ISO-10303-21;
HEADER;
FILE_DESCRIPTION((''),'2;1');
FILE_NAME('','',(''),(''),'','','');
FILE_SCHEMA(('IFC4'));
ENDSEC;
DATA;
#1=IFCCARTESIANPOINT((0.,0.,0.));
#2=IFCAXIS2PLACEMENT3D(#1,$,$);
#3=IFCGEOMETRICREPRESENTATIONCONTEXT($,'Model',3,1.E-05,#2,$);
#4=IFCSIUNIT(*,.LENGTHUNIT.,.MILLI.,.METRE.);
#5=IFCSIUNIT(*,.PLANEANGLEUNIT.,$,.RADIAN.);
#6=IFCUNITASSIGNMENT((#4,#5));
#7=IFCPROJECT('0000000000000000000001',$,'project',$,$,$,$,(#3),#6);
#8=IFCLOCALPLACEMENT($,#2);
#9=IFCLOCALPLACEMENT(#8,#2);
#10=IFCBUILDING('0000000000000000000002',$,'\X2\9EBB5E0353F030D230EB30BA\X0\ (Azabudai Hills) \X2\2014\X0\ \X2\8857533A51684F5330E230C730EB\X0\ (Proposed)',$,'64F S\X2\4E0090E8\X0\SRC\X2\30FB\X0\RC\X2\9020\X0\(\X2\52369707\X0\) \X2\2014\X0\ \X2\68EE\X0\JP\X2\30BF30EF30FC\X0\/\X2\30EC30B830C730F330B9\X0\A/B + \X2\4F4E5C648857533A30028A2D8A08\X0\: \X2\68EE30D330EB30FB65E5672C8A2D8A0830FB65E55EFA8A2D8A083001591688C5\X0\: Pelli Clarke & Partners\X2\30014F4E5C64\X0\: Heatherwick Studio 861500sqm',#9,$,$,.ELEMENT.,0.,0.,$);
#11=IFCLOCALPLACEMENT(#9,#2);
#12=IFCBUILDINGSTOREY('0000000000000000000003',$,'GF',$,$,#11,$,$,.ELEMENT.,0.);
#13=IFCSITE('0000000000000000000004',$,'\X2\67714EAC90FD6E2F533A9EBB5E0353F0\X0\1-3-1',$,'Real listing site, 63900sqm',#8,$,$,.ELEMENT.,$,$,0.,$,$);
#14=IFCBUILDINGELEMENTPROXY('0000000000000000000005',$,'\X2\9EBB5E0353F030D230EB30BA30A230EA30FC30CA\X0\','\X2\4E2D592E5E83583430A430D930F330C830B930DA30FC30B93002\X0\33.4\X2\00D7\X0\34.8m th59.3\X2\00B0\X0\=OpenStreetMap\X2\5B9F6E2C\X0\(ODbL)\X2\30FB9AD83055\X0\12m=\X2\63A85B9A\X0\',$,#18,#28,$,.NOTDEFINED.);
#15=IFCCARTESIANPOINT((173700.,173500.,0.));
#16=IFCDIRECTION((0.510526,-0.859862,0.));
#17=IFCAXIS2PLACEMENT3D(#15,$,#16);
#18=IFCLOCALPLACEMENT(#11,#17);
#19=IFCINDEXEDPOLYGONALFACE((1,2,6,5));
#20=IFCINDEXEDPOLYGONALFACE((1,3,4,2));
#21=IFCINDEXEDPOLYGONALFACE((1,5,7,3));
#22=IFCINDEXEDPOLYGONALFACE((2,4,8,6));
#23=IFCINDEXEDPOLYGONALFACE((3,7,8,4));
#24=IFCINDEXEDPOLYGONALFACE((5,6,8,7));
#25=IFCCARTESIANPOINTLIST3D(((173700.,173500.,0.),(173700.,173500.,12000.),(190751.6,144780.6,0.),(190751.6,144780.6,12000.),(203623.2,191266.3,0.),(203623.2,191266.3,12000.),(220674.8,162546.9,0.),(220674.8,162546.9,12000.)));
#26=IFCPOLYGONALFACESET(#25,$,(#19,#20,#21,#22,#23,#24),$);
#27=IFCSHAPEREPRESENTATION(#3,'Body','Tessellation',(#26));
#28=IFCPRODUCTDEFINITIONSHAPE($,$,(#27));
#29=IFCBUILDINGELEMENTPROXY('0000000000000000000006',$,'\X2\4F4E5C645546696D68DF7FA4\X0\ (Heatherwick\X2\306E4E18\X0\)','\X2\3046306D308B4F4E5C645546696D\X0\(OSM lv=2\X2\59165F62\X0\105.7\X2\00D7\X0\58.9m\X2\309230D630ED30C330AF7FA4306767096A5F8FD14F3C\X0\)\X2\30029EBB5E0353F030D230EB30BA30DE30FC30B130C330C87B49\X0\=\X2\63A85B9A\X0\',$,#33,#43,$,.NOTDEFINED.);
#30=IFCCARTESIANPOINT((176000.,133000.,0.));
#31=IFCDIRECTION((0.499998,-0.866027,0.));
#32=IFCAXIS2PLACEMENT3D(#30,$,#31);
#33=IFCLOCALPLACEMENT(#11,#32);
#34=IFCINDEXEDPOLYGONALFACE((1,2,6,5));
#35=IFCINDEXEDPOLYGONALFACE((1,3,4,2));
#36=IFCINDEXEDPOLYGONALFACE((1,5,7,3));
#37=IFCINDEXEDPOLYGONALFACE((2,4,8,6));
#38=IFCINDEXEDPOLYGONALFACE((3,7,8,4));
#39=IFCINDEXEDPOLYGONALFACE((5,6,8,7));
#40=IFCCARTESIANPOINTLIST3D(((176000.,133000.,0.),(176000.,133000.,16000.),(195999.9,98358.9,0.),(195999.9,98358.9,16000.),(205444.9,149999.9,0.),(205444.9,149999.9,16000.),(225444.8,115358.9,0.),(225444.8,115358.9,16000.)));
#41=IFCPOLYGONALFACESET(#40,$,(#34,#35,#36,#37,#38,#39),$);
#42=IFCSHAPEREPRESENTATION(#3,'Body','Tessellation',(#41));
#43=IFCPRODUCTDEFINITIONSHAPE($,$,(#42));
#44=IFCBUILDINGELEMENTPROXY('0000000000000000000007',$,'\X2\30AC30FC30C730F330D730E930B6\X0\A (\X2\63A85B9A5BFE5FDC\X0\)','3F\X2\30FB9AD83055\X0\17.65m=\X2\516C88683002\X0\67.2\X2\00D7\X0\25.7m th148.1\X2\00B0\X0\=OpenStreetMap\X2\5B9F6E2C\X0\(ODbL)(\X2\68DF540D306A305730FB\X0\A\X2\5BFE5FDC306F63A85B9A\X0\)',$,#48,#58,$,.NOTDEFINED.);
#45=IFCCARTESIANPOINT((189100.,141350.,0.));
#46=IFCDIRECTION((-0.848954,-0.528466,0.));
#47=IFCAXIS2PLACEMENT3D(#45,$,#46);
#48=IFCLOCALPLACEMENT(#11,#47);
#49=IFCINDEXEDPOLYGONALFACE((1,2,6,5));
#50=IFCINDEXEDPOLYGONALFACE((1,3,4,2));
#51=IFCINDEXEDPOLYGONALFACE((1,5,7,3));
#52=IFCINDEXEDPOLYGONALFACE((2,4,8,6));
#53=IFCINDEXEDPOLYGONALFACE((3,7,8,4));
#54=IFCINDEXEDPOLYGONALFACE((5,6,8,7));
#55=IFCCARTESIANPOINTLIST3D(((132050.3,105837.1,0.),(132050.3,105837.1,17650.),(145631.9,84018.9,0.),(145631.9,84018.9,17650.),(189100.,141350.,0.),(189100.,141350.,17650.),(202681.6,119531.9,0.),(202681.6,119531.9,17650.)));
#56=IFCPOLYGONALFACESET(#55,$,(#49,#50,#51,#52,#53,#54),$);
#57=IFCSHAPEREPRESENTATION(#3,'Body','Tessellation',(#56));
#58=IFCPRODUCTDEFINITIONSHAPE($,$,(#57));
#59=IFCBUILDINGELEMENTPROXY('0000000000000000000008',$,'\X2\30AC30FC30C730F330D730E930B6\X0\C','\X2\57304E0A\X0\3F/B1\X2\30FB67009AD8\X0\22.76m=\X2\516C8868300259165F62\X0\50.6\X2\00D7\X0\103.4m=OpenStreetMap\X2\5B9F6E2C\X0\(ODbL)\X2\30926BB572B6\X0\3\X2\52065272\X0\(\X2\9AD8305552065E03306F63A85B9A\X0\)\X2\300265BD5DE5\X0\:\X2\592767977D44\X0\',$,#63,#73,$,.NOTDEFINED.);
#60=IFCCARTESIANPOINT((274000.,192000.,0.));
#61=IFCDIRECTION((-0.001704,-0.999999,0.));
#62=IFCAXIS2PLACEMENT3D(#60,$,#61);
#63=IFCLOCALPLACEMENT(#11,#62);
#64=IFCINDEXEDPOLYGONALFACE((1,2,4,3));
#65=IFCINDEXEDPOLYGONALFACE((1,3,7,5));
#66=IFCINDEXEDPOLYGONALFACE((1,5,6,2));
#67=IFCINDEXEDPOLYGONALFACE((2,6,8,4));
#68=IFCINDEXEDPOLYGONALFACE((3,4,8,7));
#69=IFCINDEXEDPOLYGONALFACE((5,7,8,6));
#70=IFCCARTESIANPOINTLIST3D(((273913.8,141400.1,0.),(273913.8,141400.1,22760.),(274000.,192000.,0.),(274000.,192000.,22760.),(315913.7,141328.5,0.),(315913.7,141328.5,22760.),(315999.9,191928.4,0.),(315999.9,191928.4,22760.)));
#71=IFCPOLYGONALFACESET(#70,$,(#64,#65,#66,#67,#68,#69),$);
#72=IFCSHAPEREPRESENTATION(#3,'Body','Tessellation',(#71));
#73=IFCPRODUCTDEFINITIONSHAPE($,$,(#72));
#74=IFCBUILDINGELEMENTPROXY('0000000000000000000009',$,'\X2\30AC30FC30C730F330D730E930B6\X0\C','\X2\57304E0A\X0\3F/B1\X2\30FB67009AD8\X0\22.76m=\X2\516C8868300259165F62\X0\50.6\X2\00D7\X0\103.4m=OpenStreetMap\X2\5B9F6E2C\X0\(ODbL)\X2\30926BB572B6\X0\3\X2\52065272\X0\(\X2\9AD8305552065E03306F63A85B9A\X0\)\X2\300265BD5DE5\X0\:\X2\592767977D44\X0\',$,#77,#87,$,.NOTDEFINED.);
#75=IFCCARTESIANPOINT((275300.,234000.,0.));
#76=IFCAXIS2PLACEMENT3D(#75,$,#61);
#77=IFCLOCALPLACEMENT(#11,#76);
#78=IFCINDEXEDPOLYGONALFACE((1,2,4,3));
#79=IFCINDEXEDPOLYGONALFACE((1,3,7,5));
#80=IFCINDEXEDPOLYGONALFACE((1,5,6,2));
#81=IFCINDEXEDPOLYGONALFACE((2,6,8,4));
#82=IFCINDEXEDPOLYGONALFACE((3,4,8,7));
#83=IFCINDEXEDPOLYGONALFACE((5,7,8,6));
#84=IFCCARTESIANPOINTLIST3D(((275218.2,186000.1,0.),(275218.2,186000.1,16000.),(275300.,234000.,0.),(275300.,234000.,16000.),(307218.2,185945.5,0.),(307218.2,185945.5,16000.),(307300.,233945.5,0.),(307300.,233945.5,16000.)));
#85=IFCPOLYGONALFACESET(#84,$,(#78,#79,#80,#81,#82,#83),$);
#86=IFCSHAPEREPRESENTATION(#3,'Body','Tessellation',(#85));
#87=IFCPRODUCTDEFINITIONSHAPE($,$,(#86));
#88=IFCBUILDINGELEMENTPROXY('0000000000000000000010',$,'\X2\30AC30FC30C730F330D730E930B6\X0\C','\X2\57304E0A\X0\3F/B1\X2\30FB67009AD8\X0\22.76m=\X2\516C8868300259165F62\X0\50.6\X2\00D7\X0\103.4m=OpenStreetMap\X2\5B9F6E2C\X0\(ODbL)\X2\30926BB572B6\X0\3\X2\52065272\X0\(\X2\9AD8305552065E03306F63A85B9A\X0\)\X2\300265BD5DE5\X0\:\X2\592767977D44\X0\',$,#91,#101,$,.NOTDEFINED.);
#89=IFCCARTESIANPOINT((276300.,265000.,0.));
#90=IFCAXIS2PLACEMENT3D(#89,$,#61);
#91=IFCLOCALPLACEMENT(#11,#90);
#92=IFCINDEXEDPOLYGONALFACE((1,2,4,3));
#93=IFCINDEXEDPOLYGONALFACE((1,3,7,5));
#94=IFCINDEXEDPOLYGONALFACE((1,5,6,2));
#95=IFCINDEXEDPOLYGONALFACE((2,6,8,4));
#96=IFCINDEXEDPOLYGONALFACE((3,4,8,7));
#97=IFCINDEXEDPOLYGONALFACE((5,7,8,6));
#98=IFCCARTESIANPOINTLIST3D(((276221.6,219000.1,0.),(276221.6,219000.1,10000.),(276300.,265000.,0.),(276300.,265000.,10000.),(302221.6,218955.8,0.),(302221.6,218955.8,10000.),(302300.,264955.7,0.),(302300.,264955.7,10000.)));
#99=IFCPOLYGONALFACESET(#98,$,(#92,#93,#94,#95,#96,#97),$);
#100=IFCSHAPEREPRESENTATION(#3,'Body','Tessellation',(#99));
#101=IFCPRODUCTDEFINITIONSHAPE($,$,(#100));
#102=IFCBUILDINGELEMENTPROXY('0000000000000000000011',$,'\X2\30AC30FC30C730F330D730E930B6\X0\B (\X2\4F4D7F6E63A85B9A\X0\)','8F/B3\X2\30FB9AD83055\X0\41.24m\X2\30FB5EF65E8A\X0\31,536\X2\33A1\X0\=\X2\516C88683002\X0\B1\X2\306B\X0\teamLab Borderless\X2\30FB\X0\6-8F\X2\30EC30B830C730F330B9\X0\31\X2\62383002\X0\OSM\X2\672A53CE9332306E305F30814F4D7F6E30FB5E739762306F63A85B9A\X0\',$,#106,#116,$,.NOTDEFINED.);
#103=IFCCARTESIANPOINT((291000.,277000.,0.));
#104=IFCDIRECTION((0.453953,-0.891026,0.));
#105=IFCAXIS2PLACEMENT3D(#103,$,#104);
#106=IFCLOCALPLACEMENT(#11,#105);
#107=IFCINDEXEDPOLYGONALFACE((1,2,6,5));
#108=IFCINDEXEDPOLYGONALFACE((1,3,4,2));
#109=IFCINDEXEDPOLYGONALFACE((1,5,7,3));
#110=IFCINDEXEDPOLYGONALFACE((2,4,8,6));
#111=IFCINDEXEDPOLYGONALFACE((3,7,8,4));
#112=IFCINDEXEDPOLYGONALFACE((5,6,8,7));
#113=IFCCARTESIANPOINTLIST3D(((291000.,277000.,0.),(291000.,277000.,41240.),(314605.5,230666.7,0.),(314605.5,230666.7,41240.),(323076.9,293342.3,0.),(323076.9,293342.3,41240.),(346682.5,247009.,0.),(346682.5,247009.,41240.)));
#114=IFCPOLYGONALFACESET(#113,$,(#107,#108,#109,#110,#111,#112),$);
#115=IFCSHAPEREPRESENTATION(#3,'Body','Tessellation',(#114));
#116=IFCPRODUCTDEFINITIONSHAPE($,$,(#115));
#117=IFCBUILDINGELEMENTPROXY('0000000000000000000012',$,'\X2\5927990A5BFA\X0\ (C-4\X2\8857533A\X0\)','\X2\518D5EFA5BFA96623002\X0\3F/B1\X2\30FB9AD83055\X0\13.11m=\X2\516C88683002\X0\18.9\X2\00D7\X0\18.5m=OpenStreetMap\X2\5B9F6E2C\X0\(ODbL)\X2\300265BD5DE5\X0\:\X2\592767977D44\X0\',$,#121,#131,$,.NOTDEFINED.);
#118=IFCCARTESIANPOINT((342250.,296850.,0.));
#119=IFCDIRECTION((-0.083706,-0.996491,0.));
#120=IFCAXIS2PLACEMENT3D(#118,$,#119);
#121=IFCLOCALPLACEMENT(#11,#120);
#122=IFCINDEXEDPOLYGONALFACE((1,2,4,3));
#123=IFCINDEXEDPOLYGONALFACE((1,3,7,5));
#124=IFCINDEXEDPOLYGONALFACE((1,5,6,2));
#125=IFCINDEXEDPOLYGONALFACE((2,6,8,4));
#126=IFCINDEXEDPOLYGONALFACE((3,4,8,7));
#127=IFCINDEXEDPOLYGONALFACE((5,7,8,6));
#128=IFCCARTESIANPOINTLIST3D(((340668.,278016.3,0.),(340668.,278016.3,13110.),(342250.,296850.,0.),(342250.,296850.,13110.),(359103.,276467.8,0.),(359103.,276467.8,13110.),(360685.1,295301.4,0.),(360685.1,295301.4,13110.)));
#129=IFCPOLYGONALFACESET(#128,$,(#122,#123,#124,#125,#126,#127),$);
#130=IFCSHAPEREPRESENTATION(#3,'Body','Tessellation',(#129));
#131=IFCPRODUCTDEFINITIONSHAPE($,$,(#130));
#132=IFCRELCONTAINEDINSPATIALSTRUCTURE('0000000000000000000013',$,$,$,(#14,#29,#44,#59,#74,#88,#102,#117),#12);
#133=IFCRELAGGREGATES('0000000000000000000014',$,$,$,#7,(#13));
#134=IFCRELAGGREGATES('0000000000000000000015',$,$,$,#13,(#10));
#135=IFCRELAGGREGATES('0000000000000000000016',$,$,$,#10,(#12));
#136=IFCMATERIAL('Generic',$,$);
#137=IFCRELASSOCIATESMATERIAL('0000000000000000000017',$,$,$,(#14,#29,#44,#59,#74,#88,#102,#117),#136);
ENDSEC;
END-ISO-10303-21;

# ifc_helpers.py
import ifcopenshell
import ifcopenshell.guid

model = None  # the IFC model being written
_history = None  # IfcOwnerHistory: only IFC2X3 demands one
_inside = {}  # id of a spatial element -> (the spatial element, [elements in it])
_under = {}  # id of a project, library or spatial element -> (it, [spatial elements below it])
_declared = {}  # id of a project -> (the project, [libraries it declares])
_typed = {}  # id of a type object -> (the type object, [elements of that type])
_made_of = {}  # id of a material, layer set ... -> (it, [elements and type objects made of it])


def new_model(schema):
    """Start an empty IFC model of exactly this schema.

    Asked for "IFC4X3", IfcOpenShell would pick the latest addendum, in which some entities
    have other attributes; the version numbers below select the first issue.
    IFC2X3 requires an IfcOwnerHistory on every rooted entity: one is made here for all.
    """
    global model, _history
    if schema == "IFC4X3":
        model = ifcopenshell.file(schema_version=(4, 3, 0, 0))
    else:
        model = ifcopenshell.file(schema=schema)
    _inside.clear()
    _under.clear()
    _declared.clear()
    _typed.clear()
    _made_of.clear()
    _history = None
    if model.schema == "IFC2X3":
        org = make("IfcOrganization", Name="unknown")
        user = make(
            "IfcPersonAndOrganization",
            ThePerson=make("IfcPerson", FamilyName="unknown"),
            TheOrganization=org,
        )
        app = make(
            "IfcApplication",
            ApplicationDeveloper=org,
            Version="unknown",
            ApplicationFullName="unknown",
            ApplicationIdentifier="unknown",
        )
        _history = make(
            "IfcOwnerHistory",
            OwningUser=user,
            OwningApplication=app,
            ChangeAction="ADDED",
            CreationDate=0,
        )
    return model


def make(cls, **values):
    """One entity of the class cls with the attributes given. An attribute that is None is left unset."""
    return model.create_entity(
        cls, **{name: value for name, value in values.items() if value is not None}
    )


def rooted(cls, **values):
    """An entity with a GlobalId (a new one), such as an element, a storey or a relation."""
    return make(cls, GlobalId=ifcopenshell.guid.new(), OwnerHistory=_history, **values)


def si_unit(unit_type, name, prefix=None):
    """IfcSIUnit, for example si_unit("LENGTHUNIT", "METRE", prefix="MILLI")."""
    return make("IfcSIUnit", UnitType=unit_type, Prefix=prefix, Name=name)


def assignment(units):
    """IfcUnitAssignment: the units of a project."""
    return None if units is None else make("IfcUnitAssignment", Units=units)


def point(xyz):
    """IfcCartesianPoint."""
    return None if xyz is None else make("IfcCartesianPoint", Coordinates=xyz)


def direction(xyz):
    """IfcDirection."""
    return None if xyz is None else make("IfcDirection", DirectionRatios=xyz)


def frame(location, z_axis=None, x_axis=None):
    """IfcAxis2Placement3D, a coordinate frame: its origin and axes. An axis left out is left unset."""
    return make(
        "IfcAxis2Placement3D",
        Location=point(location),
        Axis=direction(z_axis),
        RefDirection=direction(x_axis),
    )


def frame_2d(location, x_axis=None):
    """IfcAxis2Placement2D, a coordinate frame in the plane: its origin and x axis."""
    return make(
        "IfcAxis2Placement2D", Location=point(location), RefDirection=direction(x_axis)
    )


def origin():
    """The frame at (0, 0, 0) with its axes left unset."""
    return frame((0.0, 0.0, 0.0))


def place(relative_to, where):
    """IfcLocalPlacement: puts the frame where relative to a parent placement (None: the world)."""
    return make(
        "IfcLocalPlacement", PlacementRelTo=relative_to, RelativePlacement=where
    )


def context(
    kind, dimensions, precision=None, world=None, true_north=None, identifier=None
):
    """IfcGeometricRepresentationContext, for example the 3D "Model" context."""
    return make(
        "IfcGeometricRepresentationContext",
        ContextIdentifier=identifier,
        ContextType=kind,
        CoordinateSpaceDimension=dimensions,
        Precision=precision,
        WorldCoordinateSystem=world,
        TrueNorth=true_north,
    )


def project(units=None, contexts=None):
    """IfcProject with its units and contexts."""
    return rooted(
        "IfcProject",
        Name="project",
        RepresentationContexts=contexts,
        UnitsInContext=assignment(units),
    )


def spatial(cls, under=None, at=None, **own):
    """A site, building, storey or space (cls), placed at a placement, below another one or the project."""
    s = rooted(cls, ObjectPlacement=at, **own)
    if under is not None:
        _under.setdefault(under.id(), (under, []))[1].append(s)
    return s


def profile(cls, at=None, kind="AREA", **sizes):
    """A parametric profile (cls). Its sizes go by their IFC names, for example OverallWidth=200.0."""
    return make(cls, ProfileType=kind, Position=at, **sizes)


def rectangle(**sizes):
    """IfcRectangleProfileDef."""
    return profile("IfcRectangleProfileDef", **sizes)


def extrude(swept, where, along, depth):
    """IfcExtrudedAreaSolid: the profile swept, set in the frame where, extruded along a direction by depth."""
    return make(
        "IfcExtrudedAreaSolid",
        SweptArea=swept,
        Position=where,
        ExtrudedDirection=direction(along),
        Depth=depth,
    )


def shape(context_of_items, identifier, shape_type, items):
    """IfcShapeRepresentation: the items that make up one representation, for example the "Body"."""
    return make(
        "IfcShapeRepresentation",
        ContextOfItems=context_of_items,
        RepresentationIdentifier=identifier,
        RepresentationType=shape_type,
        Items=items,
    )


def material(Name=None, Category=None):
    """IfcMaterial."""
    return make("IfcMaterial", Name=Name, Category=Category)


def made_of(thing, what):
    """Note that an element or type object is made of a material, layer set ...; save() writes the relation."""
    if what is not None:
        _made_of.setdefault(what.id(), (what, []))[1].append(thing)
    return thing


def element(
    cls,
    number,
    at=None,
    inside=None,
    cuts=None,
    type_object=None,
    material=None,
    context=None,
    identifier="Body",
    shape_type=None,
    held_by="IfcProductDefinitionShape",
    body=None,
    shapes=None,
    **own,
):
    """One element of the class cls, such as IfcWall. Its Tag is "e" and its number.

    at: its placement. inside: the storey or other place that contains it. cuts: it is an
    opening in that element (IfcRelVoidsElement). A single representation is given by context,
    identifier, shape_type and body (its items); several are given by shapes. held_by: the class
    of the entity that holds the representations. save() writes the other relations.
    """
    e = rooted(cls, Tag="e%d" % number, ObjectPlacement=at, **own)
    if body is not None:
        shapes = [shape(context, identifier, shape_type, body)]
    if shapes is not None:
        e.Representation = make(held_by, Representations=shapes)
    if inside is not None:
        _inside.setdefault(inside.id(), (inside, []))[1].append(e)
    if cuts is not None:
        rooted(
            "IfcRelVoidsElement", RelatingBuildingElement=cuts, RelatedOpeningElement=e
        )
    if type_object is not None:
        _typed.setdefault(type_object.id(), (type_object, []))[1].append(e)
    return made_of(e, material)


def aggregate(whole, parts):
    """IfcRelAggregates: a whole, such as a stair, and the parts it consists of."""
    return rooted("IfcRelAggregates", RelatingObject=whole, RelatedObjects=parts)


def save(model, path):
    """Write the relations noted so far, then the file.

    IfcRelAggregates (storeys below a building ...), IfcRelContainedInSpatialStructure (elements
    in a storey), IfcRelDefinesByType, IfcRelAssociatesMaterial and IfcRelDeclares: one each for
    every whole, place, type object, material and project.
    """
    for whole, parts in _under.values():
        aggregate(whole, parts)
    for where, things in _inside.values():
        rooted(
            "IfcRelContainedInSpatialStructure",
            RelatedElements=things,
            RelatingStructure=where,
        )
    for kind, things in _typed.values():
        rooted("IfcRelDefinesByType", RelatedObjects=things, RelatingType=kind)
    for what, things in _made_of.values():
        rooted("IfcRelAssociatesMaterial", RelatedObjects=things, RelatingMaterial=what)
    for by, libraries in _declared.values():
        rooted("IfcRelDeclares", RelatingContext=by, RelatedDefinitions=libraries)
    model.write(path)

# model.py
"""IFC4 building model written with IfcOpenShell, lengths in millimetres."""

from ifc_helpers import new_model, si_unit, frame, frame_2d, origin, place, context, project, spatial, rectangle, extrude, material, element, save


model = new_model("IFC4")

# Units and contexts
model_context = context("Model", 3, precision=1e-05, world=origin())
ifc_project = project(units=[si_unit("LENGTHUNIT", "METRE", prefix="MILLI"), si_unit("PLANEANGLEUNIT", "RADIAN")], contexts=[model_context])

# Site, building, storey
site_placement = place(None, origin())
site = spatial("IfcSite", under=ifc_project, at=site_placement, Name="東京都港区麻布台1-3-1", ObjectType="Real listing site, 63900sqm", CompositionType="ELEMENT", RefElevation=0.0)
building_placement = place(site_placement, origin())
building = spatial("IfcBuilding", under=site, at=building_placement, Name="麻布台ヒルズ (Azabudai Hills) — 街区全体モデル (Proposed)", ObjectType="64F S一部SRC・RC造(制震) — 森JPタワー/レジデンスA/B + 低層街区。設計: 森ビル・日本設計・日建設計、外装: Pelli Clarke & Partners、低層: Heatherwick Studio 861500sqm", CompositionType="ELEMENT", ElevationOfRefHeight=0.0, ElevationOfTerrain=0.0)
storey_placement = place(building_placement, origin())
storey = spatial("IfcBuildingStorey", under=building, at=storey_placement, Name="GF", CompositionType="ELEMENT", Elevation=0.0)

# Shared definitions
ifc_material = material(Name="Generic")

# Building element proxies
proxy_1_placement = place(storey_placement, frame((173700.0, 173500.0, 0.0), x_axis=(0.510526, -0.859862, 0.0)))
element("IfcBuildingElementProxy", 1, at=proxy_1_placement, inside=storey, material=ifc_material, Name="麻布台ヒルズアリーナ", Description="中央広場イベントスペース。33.4×34.8m th59.3°=OpenStreetMap実測(ODbL)・高さ12m=推定", PredefinedType="NOTDEFINED", context=model_context, shape_type="SweptSolid", body=[
    extrude(rectangle(XDim=33400.0, YDim=34800.0, at=frame_2d((16700.0, 17400.0))), frame((173700.0, 173500.0, 0.0), x_axis=(0.510526, -0.859862, 0.0)), (0.0, 0.0, 1.0), 12000.0),
])
proxy_2_placement = place(storey_placement, frame((176000.0, 133000.0, 0.0), x_axis=(0.499998, -0.866027, 0.0)))
element("IfcBuildingElementProxy", 2, at=proxy_2_placement, inside=storey, material=ifc_material, Name="低層商業棟群 (Heatherwickの丘)", Description="うねる低層商業(OSM lv=2外形105.7×58.9mをブロック群で有機近似)。麻布台ヒルズマーケット等=推定", PredefinedType="NOTDEFINED", context=model_context, shape_type="SweptSolid", body=[
    extrude(rectangle(XDim=40000.0, YDim=34000.0, at=frame_2d((20000.0, 17000.0))), frame((176000.0, 133000.0, 0.0), x_axis=(0.499998, -0.866027, 0.0)), (0.0, 0.0, 1.0), 16000.0),
])
proxy_3_placement = place(storey_placement, frame((189100.0, 141350.0, 0.0), x_axis=(-0.848954, -0.528466, 0.0)))
element("IfcBuildingElementProxy", 3, at=proxy_3_placement, inside=storey, material=ifc_material, Name="ガーデンプラザA (推定対応)", Description="3F・高さ17.65m=公表。67.2×25.7m th148.1°=OpenStreetMap実測(ODbL)(棟名なし・A対応は推定)", PredefinedType="NOTDEFINED", context=model_context, shape_type="SweptSolid", body=[
    extrude(rectangle(XDim=67200.0, YDim=25700.0, at=frame_2d((33600.0, 12850.0))), frame((189100.0, 141350.0, 0.0), x_axis=(-0.848954, -0.528466, 0.0)), (0.0, 0.0, 1.0), 17650.0),
])
proxy_4_placement = place(storey_placement, frame((274000.0, 192000.0, 0.0), x_axis=(-0.001704, -0.999999, 0.0)))
element("IfcBuildingElementProxy", 4, at=proxy_4_placement, inside=storey, material=ifc_material, Name="ガーデンプラザC", Description="地上3F/B1・最高22.76m=公表。外形50.6×103.4m=OpenStreetMap実測(ODbL)を段状3分割(高さ分布は推定)。施工:大林組", PredefinedType="NOTDEFINED", context=model_context, shape_type="SweptSolid", body=[
    extrude(rectangle(XDim=50600.0, YDim=42000.0, at=frame_2d((25300.0, 21000.0))), frame((274000.0, 192000.0, 0.0), x_axis=(-0.001704, -0.999999, 0.0)), (0.0, 0.0, 1.0), 22760.0),
])
proxy_5_placement = place(storey_placement, frame((275300.0, 234000.0, 0.0), x_axis=(-0.001704, -0.999999, 0.0)))
element("IfcBuildingElementProxy", 5, at=proxy_5_placement, inside=storey, material=ifc_material, Name="ガーデンプラザC", Description="地上3F/B1・最高22.76m=公表。外形50.6×103.4m=OpenStreetMap実測(ODbL)を段状3分割(高さ分布は推定)。施工:大林組", PredefinedType="NOTDEFINED", context=model_context, shape_type="SweptSolid", body=[
    extrude(rectangle(XDim=48000.0, YDim=32000.0, at=frame_2d((24000.0, 16000.0))), frame((275300.0, 234000.0, 0.0), x_axis=(-0.001704, -0.999999, 0.0)), (0.0, 0.0, 1.0), 16000.0),
])
proxy_6_placement = place(storey_placement, frame((276300.0, 265000.0, 0.0), x_axis=(-0.001704, -0.999999, 0.0)))
element("IfcBuildingElementProxy", 6, at=proxy_6_placement, inside=storey, material=ifc_material, Name="ガーデンプラザC", Description="地上3F/B1・最高22.76m=公表。外形50.6×103.4m=OpenStreetMap実測(ODbL)を段状3分割(高さ分布は推定)。施工:大林組", PredefinedType="NOTDEFINED", context=model_context, shape_type="SweptSolid", body=[
    extrude(rectangle(XDim=46000.0, YDim=26000.0, at=frame_2d((23000.0, 13000.0))), frame((276300.0, 265000.0, 0.0), x_axis=(-0.001704, -0.999999, 0.0)), (0.0, 0.0, 1.0), 10000.0),
])
proxy_7_placement = place(storey_placement, frame((291000.0, 277000.0, 0.0), x_axis=(0.453953, -0.891026, 0.0)))
element("IfcBuildingElementProxy", 7, at=proxy_7_placement, inside=storey, material=ifc_material, Name="ガーデンプラザB (位置推定)", Description="8F/B3・高さ41.24m・延床31,536㎡=公表。B1にteamLab Borderless・6-8Fレジデンス31戸。OSM未収録のため位置・平面は推定", PredefinedType="NOTDEFINED", context=model_context, shape_type="SweptSolid", body=[
    extrude(rectangle(XDim=52000.0, YDim=36000.0, at=frame_2d((26000.0, 18000.0))), frame((291000.0, 277000.0, 0.0), x_axis=(0.453953, -0.891026, 0.0)), (0.0, 0.0, 1.0), 41240.0),
])
proxy_8_placement = place(storey_placement, frame((342250.0, 296850.0, 0.0), x_axis=(-0.083706, -0.996491, 0.0)))
element("IfcBuildingElementProxy", 8, at=proxy_8_placement, inside=storey, material=ifc_material, Name="大養寺 (C-4街区)", Description="再建寺院。3F/B1・高さ13.11m=公表。18.9×18.5m=OpenStreetMap実測(ODbL)。施工:大林組", PredefinedType="NOTDEFINED", context=model_context, shape_type="SweptSolid", body=[
    extrude(rectangle(XDim=18900.0, YDim=18500.0, at=frame_2d((9450.0, 9250.0))), frame((342250.0, 296850.0, 0.0), x_axis=(-0.083706, -0.996491, 0.0)), (0.0, 0.0, 1.0), 13110.0),
])

save(model, "model.ifc")
